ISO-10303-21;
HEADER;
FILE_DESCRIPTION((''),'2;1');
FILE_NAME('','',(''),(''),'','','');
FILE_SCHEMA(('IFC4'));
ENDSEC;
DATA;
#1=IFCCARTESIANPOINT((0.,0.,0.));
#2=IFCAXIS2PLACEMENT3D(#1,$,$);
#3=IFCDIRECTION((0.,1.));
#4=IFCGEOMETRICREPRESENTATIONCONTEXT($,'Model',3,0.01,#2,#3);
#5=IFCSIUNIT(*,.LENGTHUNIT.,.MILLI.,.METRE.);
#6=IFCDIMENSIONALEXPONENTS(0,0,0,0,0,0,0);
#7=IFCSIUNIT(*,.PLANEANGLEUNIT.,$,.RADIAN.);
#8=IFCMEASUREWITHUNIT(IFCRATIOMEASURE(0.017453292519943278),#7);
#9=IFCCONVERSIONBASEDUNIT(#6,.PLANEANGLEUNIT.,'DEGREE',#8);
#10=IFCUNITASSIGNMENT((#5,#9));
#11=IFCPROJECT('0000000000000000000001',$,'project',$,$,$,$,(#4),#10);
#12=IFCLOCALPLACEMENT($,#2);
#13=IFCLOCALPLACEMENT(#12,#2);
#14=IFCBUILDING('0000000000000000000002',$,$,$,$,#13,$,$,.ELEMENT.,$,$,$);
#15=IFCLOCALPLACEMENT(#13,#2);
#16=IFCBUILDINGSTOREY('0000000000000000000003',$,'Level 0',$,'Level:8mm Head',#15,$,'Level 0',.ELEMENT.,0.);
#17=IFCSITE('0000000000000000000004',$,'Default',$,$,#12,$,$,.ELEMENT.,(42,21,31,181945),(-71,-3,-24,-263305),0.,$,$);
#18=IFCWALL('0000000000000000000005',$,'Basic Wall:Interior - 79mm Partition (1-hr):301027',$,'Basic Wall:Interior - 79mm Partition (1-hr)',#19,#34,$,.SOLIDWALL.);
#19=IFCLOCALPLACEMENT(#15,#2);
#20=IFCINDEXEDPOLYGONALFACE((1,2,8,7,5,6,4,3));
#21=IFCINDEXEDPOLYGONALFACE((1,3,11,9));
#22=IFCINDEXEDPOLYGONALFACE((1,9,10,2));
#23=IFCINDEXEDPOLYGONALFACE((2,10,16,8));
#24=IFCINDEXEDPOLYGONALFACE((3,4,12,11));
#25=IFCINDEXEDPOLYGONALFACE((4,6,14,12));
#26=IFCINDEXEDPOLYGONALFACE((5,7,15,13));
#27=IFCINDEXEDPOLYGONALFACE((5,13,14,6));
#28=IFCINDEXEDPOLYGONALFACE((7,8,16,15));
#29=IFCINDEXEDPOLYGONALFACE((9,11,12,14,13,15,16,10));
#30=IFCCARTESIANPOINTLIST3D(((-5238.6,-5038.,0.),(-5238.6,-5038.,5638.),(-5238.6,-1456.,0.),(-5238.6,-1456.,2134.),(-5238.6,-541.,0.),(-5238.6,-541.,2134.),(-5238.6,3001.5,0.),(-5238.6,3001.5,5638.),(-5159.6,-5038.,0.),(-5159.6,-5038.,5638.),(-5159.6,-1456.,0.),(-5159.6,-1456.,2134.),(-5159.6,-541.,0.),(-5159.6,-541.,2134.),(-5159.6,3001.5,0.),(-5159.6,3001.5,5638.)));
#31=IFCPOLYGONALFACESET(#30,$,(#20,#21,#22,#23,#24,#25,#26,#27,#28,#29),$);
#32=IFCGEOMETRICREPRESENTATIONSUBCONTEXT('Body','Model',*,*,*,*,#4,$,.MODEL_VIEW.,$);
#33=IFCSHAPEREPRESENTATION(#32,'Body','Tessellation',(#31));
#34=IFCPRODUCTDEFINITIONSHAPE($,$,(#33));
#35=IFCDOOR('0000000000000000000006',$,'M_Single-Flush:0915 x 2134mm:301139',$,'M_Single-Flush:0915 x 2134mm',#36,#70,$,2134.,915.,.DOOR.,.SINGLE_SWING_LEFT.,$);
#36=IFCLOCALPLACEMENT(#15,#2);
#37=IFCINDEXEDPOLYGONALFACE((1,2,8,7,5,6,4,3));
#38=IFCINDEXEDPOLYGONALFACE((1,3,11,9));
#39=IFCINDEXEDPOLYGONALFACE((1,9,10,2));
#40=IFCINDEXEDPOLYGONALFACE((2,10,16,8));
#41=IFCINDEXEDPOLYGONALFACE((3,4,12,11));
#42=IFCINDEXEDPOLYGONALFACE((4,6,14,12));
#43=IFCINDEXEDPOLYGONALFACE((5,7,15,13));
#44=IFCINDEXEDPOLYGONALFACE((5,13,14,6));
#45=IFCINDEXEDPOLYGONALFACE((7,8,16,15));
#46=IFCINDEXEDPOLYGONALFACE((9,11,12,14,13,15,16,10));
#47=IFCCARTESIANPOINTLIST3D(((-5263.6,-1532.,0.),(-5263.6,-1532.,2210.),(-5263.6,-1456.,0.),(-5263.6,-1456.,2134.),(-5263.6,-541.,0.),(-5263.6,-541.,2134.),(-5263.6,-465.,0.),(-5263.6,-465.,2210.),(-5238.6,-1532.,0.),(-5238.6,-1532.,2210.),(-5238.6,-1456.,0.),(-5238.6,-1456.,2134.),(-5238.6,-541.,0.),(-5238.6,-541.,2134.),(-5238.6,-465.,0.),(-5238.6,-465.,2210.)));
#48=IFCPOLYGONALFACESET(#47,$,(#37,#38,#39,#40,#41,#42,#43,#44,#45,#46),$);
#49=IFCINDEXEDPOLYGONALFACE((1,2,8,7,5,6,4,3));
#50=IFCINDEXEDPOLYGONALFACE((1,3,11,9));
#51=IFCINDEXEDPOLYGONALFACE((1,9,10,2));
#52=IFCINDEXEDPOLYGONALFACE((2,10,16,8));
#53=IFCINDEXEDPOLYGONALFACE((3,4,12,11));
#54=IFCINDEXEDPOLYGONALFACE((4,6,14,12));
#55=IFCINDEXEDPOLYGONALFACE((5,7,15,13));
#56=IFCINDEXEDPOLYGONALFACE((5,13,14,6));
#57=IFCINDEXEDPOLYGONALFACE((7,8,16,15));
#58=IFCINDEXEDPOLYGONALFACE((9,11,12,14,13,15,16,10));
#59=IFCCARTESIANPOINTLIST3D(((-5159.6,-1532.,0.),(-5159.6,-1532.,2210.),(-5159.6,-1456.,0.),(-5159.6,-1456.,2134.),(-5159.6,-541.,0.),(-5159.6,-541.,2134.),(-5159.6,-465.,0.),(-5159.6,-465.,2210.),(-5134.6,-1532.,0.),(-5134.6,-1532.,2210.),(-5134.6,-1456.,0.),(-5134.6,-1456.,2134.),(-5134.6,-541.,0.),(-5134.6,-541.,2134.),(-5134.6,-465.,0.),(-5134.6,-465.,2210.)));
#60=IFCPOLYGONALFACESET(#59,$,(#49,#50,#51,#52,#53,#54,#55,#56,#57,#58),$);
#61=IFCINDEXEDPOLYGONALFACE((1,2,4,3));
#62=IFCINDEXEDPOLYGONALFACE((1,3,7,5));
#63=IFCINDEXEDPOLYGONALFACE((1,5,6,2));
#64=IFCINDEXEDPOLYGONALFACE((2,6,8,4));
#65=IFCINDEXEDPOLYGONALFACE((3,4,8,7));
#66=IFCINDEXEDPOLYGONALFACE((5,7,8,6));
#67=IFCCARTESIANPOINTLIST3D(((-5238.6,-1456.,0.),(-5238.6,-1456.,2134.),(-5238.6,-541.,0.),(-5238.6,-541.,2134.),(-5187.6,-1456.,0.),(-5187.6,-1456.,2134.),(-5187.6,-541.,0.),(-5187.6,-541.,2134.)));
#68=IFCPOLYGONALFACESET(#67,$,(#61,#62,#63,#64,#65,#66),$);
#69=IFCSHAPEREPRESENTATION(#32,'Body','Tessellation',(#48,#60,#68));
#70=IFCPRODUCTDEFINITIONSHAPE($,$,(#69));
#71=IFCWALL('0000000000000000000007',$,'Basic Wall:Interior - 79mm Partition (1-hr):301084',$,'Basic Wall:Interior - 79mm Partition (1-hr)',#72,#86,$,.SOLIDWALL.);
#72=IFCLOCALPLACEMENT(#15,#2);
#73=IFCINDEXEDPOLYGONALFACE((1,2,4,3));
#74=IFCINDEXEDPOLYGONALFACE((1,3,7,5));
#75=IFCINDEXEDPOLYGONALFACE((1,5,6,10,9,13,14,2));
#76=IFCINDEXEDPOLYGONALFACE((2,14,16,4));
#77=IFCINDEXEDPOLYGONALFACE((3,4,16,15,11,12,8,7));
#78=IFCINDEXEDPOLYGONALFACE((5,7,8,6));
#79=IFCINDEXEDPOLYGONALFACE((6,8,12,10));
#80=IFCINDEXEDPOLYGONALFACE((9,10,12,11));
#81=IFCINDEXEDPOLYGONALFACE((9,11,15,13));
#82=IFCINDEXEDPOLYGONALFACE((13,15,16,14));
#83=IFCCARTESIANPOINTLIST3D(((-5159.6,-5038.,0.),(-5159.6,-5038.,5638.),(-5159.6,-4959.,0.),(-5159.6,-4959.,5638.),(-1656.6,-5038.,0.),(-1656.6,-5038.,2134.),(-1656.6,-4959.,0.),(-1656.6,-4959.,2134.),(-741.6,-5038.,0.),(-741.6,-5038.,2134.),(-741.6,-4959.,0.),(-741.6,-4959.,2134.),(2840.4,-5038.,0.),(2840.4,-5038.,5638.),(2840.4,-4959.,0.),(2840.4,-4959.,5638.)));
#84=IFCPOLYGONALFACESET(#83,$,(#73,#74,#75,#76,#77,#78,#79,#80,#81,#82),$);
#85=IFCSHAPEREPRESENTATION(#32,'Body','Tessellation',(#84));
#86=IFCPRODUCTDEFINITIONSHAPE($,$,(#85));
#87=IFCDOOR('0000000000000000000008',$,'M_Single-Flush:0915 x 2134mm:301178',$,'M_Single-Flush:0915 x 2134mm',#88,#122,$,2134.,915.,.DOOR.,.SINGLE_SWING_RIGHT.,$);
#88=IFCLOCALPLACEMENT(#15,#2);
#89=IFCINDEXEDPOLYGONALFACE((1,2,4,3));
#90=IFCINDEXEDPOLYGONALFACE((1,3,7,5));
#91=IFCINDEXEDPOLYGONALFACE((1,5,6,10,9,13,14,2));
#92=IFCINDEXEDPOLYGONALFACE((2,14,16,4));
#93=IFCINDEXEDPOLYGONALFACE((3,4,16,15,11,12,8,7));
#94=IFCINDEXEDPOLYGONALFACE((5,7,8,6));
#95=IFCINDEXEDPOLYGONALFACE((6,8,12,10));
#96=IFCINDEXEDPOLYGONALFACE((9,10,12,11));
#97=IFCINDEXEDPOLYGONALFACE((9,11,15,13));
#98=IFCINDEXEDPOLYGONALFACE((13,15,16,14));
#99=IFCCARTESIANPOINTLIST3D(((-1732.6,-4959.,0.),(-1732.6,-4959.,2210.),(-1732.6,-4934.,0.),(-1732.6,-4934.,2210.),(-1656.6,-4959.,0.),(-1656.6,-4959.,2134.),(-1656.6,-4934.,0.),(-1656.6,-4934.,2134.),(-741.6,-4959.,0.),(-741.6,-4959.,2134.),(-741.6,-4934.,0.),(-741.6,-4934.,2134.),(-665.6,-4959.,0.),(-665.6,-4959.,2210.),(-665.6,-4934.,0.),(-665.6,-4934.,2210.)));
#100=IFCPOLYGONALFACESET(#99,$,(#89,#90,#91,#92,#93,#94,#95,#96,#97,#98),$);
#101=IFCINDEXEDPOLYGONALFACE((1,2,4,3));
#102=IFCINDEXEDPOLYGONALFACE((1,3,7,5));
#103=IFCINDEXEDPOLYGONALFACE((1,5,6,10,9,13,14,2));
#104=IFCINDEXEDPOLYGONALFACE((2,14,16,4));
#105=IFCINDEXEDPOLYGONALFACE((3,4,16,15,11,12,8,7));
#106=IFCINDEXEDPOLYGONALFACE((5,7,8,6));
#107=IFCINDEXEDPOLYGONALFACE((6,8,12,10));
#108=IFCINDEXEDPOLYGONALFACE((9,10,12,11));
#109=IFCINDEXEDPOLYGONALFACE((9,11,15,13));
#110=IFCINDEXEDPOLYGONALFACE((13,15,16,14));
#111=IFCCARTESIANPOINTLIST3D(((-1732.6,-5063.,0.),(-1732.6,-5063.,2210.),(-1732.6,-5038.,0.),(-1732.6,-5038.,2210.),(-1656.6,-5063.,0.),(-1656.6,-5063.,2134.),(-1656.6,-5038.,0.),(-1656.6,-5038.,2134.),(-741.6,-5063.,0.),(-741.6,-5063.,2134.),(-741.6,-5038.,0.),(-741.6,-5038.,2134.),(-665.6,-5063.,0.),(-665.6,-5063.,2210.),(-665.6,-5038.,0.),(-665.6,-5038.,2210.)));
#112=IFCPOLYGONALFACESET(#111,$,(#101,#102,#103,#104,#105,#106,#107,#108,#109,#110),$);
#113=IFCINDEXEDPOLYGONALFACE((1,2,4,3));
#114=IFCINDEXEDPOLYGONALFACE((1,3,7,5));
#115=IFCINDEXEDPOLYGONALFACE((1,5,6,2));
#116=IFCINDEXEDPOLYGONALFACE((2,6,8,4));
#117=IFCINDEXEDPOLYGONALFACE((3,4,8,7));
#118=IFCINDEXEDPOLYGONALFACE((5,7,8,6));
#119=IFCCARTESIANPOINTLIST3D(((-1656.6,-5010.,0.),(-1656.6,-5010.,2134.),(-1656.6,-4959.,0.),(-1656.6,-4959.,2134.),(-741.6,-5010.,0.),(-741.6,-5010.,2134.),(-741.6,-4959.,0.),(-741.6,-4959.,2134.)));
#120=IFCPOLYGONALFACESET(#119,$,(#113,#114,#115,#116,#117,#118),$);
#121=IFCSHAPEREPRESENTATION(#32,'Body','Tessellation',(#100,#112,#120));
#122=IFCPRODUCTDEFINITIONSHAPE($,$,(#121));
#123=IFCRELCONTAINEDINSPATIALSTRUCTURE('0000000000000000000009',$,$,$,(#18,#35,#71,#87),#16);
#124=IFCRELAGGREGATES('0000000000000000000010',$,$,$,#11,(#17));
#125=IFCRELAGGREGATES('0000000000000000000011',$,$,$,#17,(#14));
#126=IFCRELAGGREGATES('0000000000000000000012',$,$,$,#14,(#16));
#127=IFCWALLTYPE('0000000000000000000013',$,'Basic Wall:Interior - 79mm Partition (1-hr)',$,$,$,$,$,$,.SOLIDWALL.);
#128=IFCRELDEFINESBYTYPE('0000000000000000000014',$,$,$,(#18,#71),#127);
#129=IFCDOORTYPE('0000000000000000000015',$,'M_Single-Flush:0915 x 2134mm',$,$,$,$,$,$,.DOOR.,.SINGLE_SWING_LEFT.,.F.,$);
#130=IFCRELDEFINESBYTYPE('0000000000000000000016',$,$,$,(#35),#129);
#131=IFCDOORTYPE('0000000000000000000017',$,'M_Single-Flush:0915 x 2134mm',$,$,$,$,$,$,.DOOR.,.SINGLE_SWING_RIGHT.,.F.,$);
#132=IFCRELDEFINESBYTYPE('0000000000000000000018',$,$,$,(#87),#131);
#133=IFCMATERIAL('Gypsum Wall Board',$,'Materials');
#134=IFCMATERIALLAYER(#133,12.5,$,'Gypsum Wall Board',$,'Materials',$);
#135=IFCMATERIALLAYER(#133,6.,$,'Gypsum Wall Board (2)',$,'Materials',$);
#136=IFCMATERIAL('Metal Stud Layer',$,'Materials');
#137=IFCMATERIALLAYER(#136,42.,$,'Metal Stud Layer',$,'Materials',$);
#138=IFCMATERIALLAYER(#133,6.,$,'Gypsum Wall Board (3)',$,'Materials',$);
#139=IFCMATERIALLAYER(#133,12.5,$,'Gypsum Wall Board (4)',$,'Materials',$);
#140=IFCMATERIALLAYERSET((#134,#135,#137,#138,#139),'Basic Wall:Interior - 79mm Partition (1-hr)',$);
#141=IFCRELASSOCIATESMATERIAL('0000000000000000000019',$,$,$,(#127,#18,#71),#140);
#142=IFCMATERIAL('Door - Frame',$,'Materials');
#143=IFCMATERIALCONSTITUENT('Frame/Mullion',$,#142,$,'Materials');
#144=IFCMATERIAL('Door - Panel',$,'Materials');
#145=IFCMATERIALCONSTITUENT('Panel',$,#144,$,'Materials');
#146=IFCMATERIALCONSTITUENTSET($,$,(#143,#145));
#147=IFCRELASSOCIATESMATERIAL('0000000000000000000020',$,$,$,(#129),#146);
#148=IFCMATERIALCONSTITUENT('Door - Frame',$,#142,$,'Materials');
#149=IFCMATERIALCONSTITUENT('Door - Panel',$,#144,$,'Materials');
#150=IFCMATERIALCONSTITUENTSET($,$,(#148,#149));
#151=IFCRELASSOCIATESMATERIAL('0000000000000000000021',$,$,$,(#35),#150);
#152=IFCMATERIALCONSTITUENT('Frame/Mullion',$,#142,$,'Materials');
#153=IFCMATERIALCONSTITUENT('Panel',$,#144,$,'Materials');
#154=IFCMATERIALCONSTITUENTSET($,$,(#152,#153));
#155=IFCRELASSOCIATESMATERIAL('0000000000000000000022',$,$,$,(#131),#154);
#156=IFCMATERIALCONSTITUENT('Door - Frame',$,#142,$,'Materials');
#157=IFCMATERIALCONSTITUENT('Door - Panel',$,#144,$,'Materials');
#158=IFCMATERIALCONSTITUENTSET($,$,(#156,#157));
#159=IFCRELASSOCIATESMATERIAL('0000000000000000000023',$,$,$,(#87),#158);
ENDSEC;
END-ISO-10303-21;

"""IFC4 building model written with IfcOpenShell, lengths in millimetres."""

from ifc_helpers import new_model, entity, si_unit, converted_unit, direction, frame, frame_2d, origin, origin_2d_with_axis, place, context, subcontext, project, spatial, polyline, rectangle, outline, extrude, clip, bounded_halfspace, source, transform, mapped, material, layer, layer_set, layer_usage, constituent, constituent_set, type_object, type_shapes, element, fill, save


model = new_model("IFC4")

# Units and contexts
model_context = context("Model", 3, precision=0.01, world=origin(), true_north=direction((0.0, 1.0)))
body_context = subcontext(model_context, "Body", "Model", "MODEL_VIEW")
ifc_project = project(units=[si_unit("LENGTHUNIT", "METRE", prefix="MILLI"), converted_unit("PLANEANGLEUNIT", "DEGREE", entity("IfcRatioMeasure", 0.017453292519943278), si_unit("PLANEANGLEUNIT", "RADIAN"), dimensions=[0, 0, 0, 0, 0, 0, 0])], contexts=[model_context])

# Site, building, storey
site_placement = place(None, origin())
site = spatial("IfcSite", under=ifc_project, at=site_placement, Name="Default", CompositionType="ELEMENT", RefLatitude=(42, 21, 31, 181945), RefLongitude=(-71, -3, -24, -263305), RefElevation=0.0)
building_placement = place(site_placement, origin())
building = spatial("IfcBuilding", under=site, at=building_placement, CompositionType="ELEMENT")
storey_placement = place(building_placement, origin())
storey = spatial("IfcBuildingStorey", under=building, at=storey_placement, Name="Level 0", ObjectType="Level:8mm Head", LongName="Level 0", CompositionType="ELEMENT", Elevation=0.0)

# Shared definitions
ifc_material_1 = material(Name="Metal Stud Layer", Category="Materials")
ifc_material_2 = material(Name="Gypsum Wall Board", Category="Materials")
ifc_material_3 = material(Name="Door - Frame", Category="Materials")
ifc_material_4 = material(Name="Door - Panel", Category="Materials")

# Walls, openings, doors
ifc_layer_1 = layer(ifc_material_2, 12.5, Name="Gypsum Wall Board", Category="Materials")
ifc_layer_2 = layer(ifc_material_2, 6.0, Name="Gypsum Wall Board (2)", Category="Materials")
ifc_layer_3 = layer(ifc_material_1, 42.0, Name="Metal Stud Layer", Category="Materials")
ifc_layer_4 = layer(ifc_material_2, 6.0, Name="Gypsum Wall Board (3)", Category="Materials")
ifc_layer_5 = layer(ifc_material_2, 12.5, Name="Gypsum Wall Board (4)", Category="Materials")
ifc_layer_set_1 = layer_set([ifc_layer_1, ifc_layer_2, ifc_layer_3, ifc_layer_4, ifc_layer_5], Name="Basic Wall:Interior - 79mm Partition (1-hr)")
ifc_layer_usage_1 = layer_usage(ifc_layer_set_1, "AXIS2", "NEGATIVE", 39.5)
wall_type_1 = type_object("IfcWallType", Name="Basic Wall:Interior - 79mm Partition (1-hr)", PredefinedType="SOLIDWALL", material=ifc_layer_set_1)
wall_1_placement = place(storey_placement, frame((-5199.1, 3001.5, 0.0), z_axis=(0.0, 0.0, 1.0), x_axis=(0.0, -1.0, 0.0)))
wall_1 = element("IfcWall", 1, at=wall_1_placement, inside=storey, type_object=wall_type_1, material=ifc_layer_usage_1, Name="Basic Wall:Interior - 79mm Partition (1-hr):301027", ObjectType="Basic Wall:Interior - 79mm Partition (1-hr)", PredefinedType="SOLIDWALL", context=body_context, shape_type="Clipping", body=[
    clip(extrude(rectangle(XDim=8039.5, YDim=79.0, at=frame_2d((4019.8, 0.0), x_axis=(1.0, 0.0))), origin(), (0.0, 0.0, 1.0), 5638.0), bounded_halfspace(frame((0.0, -39.5, 5638.0), z_axis=(0.0, 0.0, -1.0), x_axis=(1.0, 0.0, 0.0)), True, frame((0.0, -39.5, 5638.0)), polyline([(0.0, 0.0), (2450439.6, 0.0), (2450439.6, 24079.2), (2426360.4, 24079.2), (0.0, 24079.2), (0.0, 0.0)]))),
])
opening_1_placement = place(wall_1_placement, frame((4457.5, 39.5, 0.0)))
opening_1 = element("IfcOpeningElement", 2, at=opening_1_placement, cuts=wall_1, PredefinedType="OPENING", context=body_context, shape_type="SweptSolid", body=[
    extrude(rectangle(XDim=915.0, YDim=2134.0, at=frame_2d((1067.0, 457.5), x_axis=(0.0, -1.0))), frame((0.0, 0.0, 0.0), z_axis=(0.0, -1.0, 0.0), x_axis=(0.0, 0.0, 1.0)), (0.0, 0.0, 1.0), 79.0),
])
ifc_constituent_1 = constituent(ifc_material_3, Name="Door - Frame", Category="Materials")
ifc_constituent_2 = constituent(ifc_material_4, Name="Door - Panel", Category="Materials")
ifc_constituent_set_1 = constituent_set(constituents=[ifc_constituent_1, ifc_constituent_2])
ifc_constituent_3 = constituent(ifc_material_3, Name="Frame/Mullion", Category="Materials")
ifc_constituent_4 = constituent(ifc_material_4, Name="Panel", Category="Materials")
ifc_constituent_set_2 = constituent_set(constituents=[ifc_constituent_3, ifc_constituent_4])
door_type_1 = type_object("IfcDoorType", Name="M_Single-Flush:0915 x 2134mm", OperationType="SINGLE_SWING_LEFT", ParameterTakesPrecedence=False, PredefinedType="DOOR", material=ifc_constituent_set_2)
shared_shape_1 = source(origin(), body_context, "Body", "SweptSolid", [
    extrude(outline(polyline([(-533.5, -1124.0), (533.5, -1124.0), (533.5, 1086.0), (457.5, 1086.0), (457.5, -1048.0), (-457.5, -1048.0), (-457.5, 1086.0), (-533.5, 1086.0), (-533.5, -1124.0)])), frame((457.5, 104.0, 1086.0), z_axis=(0.0, -1.0, 0.0), x_axis=(-1.0, 0.0, 0.0)), (0.0, 0.0, 1.0), 25.0),
    extrude(outline(polyline([(-1124.0, -533.5), (1086.0, -533.5), (1086.0, -457.5), (-1048.0, -457.5), (-1048.0, 457.5), (1086.0, 457.5), (1086.0, 533.5), (-1124.0, 533.5), (-1124.0, -533.5)])), frame((457.5, 0.0, 1086.0), z_axis=(0.0, -1.0, 0.0), x_axis=(0.0, 0.0, -1.0)), (0.0, 0.0, 1.0), 25.0),
    extrude(rectangle(XDim=915.0, YDim=51.0, at=origin_2d_with_axis()), frame((457.5, 53.5, 0.0)), (0.0, 0.0, 1.0), 2134.0),
])
type_shapes(door_type_1, [shared_shape_1])
door_1_placement = place(opening_1_placement, frame((0.0, 0.0, 0.0), z_axis=(0.0, 0.0, 1.0), x_axis=(-1.0, 0.0, 0.0)))
door_1 = element("IfcDoor", 3, at=door_1_placement, inside=storey, type_object=door_type_1, material=ifc_constituent_set_1, Name="M_Single-Flush:0915 x 2134mm:301139", ObjectType="M_Single-Flush:0915 x 2134mm", OperationType="SINGLE_SWING_LEFT", OverallHeight=2134.0, OverallWidth=915.0, PredefinedType="DOOR", context=body_context, shape_type="MappedRepresentation", body=[
    mapped(shared_shape_1, transform((0.0, 0.0, 0.0), scale=1.0)),
])
fill(opening_1, door_1)
wall_2_placement = place(storey_placement, frame((-5159.6, -4998.5, 0.0)))
wall_2 = element("IfcWall", 4, at=wall_2_placement, inside=storey, type_object=wall_type_1, material=ifc_layer_usage_1, Name="Basic Wall:Interior - 79mm Partition (1-hr):301084", ObjectType="Basic Wall:Interior - 79mm Partition (1-hr)", PredefinedType="SOLIDWALL", context=body_context, shape_type="Clipping", body=[
    clip(extrude(rectangle(XDim=8000.0, YDim=79.0, at=frame_2d((4000.0, 0.0), x_axis=(1.0, 0.0))), origin(), (0.0, 0.0, 1.0), 5638.0), bounded_halfspace(frame((0.0, -39.5, 5638.0), z_axis=(0.0, 0.0, -1.0), x_axis=(0.0, -1.0, 0.0)), True, frame((0.0, -39.5, 5638.0)), polyline([(0.0, 0.0), (2414320.8, 0.0), (2438400.0, 0.0), (2438400.0, 24079.2), (0.0, 24079.2), (0.0, 0.0)]))),
])
opening_2_placement = place(wall_2_placement, frame((3503.0, -39.5, 0.0)))
opening_2 = element("IfcOpeningElement", 5, at=opening_2_placement, cuts=wall_2, PredefinedType="OPENING", context=body_context, shape_type="SweptSolid", body=[
    extrude(rectangle(XDim=915.0, YDim=2134.0, at=frame_2d((1067.0, 457.5), x_axis=(0.0, 1.0))), frame((0.0, 0.0, 0.0), z_axis=(0.0, 1.0, 0.0), x_axis=(0.0, 0.0, 1.0)), (0.0, 0.0, 1.0), 79.0),
])
ifc_constituent_5 = constituent(ifc_material_3, Name="Door - Frame", Category="Materials")
ifc_constituent_6 = constituent(ifc_material_4, Name="Door - Panel", Category="Materials")
ifc_constituent_set_3 = constituent_set(constituents=[ifc_constituent_5, ifc_constituent_6])
ifc_constituent_7 = constituent(ifc_material_3, Name="Frame/Mullion", Category="Materials")
ifc_constituent_8 = constituent(ifc_material_4, Name="Panel", Category="Materials")
ifc_constituent_set_4 = constituent_set(constituents=[ifc_constituent_7, ifc_constituent_8])
door_type_2 = type_object("IfcDoorType", Name="M_Single-Flush:0915 x 2134mm", OperationType="SINGLE_SWING_RIGHT", ParameterTakesPrecedence=False, PredefinedType="DOOR", material=ifc_constituent_set_4)
shared_shape_2 = source(origin(), body_context, "Body", "SweptSolid", [
    extrude(outline(polyline([(-533.5, -1124.0), (533.5, -1124.0), (533.5, 1086.0), (457.5, 1086.0), (457.5, -1048.0), (-457.5, -1048.0), (-457.5, 1086.0), (-533.5, 1086.0), (-533.5, -1124.0)])), frame((457.5, 79.0, 1086.0), z_axis=(0.0, 1.0, 0.0), x_axis=(1.0, 0.0, 0.0)), (0.0, 0.0, 1.0), 25.0),
    extrude(outline(polyline([(-1124.0, -533.5), (1086.0, -533.5), (1086.0, -457.5), (-1048.0, -457.5), (-1048.0, 457.5), (1086.0, 457.5), (1086.0, 533.5), (-1124.0, 533.5), (-1124.0, -533.5)])), frame((457.5, -25.0, 1086.0), z_axis=(0.0, 1.0, 0.0), x_axis=(0.0, 0.0, -1.0)), (0.0, 0.0, 1.0), 25.0),
    extrude(rectangle(XDim=51.0, YDim=915.0, at=origin_2d_with_axis()), frame((457.5, 53.5, 0.0), z_axis=(0.0, 0.0, 1.0), x_axis=(0.0, 1.0, 0.0)), (0.0, 0.0, 1.0), 2134.0),
])
type_shapes(door_type_2, [shared_shape_2])
door_2_placement = place(opening_2_placement, origin())
door_2 = element("IfcDoor", 6, at=door_2_placement, inside=storey, type_object=door_type_2, material=ifc_constituent_set_3, Name="M_Single-Flush:0915 x 2134mm:301178", ObjectType="M_Single-Flush:0915 x 2134mm", OperationType="SINGLE_SWING_RIGHT", OverallHeight=2134.0, OverallWidth=915.0, PredefinedType="DOOR", context=body_context, shape_type="MappedRepresentation", body=[
    mapped(shared_shape_2, transform((0.0, 0.0, 0.0), scale=1.0)),
])
fill(opening_2, door_2)

save(model, "model.ifc")
